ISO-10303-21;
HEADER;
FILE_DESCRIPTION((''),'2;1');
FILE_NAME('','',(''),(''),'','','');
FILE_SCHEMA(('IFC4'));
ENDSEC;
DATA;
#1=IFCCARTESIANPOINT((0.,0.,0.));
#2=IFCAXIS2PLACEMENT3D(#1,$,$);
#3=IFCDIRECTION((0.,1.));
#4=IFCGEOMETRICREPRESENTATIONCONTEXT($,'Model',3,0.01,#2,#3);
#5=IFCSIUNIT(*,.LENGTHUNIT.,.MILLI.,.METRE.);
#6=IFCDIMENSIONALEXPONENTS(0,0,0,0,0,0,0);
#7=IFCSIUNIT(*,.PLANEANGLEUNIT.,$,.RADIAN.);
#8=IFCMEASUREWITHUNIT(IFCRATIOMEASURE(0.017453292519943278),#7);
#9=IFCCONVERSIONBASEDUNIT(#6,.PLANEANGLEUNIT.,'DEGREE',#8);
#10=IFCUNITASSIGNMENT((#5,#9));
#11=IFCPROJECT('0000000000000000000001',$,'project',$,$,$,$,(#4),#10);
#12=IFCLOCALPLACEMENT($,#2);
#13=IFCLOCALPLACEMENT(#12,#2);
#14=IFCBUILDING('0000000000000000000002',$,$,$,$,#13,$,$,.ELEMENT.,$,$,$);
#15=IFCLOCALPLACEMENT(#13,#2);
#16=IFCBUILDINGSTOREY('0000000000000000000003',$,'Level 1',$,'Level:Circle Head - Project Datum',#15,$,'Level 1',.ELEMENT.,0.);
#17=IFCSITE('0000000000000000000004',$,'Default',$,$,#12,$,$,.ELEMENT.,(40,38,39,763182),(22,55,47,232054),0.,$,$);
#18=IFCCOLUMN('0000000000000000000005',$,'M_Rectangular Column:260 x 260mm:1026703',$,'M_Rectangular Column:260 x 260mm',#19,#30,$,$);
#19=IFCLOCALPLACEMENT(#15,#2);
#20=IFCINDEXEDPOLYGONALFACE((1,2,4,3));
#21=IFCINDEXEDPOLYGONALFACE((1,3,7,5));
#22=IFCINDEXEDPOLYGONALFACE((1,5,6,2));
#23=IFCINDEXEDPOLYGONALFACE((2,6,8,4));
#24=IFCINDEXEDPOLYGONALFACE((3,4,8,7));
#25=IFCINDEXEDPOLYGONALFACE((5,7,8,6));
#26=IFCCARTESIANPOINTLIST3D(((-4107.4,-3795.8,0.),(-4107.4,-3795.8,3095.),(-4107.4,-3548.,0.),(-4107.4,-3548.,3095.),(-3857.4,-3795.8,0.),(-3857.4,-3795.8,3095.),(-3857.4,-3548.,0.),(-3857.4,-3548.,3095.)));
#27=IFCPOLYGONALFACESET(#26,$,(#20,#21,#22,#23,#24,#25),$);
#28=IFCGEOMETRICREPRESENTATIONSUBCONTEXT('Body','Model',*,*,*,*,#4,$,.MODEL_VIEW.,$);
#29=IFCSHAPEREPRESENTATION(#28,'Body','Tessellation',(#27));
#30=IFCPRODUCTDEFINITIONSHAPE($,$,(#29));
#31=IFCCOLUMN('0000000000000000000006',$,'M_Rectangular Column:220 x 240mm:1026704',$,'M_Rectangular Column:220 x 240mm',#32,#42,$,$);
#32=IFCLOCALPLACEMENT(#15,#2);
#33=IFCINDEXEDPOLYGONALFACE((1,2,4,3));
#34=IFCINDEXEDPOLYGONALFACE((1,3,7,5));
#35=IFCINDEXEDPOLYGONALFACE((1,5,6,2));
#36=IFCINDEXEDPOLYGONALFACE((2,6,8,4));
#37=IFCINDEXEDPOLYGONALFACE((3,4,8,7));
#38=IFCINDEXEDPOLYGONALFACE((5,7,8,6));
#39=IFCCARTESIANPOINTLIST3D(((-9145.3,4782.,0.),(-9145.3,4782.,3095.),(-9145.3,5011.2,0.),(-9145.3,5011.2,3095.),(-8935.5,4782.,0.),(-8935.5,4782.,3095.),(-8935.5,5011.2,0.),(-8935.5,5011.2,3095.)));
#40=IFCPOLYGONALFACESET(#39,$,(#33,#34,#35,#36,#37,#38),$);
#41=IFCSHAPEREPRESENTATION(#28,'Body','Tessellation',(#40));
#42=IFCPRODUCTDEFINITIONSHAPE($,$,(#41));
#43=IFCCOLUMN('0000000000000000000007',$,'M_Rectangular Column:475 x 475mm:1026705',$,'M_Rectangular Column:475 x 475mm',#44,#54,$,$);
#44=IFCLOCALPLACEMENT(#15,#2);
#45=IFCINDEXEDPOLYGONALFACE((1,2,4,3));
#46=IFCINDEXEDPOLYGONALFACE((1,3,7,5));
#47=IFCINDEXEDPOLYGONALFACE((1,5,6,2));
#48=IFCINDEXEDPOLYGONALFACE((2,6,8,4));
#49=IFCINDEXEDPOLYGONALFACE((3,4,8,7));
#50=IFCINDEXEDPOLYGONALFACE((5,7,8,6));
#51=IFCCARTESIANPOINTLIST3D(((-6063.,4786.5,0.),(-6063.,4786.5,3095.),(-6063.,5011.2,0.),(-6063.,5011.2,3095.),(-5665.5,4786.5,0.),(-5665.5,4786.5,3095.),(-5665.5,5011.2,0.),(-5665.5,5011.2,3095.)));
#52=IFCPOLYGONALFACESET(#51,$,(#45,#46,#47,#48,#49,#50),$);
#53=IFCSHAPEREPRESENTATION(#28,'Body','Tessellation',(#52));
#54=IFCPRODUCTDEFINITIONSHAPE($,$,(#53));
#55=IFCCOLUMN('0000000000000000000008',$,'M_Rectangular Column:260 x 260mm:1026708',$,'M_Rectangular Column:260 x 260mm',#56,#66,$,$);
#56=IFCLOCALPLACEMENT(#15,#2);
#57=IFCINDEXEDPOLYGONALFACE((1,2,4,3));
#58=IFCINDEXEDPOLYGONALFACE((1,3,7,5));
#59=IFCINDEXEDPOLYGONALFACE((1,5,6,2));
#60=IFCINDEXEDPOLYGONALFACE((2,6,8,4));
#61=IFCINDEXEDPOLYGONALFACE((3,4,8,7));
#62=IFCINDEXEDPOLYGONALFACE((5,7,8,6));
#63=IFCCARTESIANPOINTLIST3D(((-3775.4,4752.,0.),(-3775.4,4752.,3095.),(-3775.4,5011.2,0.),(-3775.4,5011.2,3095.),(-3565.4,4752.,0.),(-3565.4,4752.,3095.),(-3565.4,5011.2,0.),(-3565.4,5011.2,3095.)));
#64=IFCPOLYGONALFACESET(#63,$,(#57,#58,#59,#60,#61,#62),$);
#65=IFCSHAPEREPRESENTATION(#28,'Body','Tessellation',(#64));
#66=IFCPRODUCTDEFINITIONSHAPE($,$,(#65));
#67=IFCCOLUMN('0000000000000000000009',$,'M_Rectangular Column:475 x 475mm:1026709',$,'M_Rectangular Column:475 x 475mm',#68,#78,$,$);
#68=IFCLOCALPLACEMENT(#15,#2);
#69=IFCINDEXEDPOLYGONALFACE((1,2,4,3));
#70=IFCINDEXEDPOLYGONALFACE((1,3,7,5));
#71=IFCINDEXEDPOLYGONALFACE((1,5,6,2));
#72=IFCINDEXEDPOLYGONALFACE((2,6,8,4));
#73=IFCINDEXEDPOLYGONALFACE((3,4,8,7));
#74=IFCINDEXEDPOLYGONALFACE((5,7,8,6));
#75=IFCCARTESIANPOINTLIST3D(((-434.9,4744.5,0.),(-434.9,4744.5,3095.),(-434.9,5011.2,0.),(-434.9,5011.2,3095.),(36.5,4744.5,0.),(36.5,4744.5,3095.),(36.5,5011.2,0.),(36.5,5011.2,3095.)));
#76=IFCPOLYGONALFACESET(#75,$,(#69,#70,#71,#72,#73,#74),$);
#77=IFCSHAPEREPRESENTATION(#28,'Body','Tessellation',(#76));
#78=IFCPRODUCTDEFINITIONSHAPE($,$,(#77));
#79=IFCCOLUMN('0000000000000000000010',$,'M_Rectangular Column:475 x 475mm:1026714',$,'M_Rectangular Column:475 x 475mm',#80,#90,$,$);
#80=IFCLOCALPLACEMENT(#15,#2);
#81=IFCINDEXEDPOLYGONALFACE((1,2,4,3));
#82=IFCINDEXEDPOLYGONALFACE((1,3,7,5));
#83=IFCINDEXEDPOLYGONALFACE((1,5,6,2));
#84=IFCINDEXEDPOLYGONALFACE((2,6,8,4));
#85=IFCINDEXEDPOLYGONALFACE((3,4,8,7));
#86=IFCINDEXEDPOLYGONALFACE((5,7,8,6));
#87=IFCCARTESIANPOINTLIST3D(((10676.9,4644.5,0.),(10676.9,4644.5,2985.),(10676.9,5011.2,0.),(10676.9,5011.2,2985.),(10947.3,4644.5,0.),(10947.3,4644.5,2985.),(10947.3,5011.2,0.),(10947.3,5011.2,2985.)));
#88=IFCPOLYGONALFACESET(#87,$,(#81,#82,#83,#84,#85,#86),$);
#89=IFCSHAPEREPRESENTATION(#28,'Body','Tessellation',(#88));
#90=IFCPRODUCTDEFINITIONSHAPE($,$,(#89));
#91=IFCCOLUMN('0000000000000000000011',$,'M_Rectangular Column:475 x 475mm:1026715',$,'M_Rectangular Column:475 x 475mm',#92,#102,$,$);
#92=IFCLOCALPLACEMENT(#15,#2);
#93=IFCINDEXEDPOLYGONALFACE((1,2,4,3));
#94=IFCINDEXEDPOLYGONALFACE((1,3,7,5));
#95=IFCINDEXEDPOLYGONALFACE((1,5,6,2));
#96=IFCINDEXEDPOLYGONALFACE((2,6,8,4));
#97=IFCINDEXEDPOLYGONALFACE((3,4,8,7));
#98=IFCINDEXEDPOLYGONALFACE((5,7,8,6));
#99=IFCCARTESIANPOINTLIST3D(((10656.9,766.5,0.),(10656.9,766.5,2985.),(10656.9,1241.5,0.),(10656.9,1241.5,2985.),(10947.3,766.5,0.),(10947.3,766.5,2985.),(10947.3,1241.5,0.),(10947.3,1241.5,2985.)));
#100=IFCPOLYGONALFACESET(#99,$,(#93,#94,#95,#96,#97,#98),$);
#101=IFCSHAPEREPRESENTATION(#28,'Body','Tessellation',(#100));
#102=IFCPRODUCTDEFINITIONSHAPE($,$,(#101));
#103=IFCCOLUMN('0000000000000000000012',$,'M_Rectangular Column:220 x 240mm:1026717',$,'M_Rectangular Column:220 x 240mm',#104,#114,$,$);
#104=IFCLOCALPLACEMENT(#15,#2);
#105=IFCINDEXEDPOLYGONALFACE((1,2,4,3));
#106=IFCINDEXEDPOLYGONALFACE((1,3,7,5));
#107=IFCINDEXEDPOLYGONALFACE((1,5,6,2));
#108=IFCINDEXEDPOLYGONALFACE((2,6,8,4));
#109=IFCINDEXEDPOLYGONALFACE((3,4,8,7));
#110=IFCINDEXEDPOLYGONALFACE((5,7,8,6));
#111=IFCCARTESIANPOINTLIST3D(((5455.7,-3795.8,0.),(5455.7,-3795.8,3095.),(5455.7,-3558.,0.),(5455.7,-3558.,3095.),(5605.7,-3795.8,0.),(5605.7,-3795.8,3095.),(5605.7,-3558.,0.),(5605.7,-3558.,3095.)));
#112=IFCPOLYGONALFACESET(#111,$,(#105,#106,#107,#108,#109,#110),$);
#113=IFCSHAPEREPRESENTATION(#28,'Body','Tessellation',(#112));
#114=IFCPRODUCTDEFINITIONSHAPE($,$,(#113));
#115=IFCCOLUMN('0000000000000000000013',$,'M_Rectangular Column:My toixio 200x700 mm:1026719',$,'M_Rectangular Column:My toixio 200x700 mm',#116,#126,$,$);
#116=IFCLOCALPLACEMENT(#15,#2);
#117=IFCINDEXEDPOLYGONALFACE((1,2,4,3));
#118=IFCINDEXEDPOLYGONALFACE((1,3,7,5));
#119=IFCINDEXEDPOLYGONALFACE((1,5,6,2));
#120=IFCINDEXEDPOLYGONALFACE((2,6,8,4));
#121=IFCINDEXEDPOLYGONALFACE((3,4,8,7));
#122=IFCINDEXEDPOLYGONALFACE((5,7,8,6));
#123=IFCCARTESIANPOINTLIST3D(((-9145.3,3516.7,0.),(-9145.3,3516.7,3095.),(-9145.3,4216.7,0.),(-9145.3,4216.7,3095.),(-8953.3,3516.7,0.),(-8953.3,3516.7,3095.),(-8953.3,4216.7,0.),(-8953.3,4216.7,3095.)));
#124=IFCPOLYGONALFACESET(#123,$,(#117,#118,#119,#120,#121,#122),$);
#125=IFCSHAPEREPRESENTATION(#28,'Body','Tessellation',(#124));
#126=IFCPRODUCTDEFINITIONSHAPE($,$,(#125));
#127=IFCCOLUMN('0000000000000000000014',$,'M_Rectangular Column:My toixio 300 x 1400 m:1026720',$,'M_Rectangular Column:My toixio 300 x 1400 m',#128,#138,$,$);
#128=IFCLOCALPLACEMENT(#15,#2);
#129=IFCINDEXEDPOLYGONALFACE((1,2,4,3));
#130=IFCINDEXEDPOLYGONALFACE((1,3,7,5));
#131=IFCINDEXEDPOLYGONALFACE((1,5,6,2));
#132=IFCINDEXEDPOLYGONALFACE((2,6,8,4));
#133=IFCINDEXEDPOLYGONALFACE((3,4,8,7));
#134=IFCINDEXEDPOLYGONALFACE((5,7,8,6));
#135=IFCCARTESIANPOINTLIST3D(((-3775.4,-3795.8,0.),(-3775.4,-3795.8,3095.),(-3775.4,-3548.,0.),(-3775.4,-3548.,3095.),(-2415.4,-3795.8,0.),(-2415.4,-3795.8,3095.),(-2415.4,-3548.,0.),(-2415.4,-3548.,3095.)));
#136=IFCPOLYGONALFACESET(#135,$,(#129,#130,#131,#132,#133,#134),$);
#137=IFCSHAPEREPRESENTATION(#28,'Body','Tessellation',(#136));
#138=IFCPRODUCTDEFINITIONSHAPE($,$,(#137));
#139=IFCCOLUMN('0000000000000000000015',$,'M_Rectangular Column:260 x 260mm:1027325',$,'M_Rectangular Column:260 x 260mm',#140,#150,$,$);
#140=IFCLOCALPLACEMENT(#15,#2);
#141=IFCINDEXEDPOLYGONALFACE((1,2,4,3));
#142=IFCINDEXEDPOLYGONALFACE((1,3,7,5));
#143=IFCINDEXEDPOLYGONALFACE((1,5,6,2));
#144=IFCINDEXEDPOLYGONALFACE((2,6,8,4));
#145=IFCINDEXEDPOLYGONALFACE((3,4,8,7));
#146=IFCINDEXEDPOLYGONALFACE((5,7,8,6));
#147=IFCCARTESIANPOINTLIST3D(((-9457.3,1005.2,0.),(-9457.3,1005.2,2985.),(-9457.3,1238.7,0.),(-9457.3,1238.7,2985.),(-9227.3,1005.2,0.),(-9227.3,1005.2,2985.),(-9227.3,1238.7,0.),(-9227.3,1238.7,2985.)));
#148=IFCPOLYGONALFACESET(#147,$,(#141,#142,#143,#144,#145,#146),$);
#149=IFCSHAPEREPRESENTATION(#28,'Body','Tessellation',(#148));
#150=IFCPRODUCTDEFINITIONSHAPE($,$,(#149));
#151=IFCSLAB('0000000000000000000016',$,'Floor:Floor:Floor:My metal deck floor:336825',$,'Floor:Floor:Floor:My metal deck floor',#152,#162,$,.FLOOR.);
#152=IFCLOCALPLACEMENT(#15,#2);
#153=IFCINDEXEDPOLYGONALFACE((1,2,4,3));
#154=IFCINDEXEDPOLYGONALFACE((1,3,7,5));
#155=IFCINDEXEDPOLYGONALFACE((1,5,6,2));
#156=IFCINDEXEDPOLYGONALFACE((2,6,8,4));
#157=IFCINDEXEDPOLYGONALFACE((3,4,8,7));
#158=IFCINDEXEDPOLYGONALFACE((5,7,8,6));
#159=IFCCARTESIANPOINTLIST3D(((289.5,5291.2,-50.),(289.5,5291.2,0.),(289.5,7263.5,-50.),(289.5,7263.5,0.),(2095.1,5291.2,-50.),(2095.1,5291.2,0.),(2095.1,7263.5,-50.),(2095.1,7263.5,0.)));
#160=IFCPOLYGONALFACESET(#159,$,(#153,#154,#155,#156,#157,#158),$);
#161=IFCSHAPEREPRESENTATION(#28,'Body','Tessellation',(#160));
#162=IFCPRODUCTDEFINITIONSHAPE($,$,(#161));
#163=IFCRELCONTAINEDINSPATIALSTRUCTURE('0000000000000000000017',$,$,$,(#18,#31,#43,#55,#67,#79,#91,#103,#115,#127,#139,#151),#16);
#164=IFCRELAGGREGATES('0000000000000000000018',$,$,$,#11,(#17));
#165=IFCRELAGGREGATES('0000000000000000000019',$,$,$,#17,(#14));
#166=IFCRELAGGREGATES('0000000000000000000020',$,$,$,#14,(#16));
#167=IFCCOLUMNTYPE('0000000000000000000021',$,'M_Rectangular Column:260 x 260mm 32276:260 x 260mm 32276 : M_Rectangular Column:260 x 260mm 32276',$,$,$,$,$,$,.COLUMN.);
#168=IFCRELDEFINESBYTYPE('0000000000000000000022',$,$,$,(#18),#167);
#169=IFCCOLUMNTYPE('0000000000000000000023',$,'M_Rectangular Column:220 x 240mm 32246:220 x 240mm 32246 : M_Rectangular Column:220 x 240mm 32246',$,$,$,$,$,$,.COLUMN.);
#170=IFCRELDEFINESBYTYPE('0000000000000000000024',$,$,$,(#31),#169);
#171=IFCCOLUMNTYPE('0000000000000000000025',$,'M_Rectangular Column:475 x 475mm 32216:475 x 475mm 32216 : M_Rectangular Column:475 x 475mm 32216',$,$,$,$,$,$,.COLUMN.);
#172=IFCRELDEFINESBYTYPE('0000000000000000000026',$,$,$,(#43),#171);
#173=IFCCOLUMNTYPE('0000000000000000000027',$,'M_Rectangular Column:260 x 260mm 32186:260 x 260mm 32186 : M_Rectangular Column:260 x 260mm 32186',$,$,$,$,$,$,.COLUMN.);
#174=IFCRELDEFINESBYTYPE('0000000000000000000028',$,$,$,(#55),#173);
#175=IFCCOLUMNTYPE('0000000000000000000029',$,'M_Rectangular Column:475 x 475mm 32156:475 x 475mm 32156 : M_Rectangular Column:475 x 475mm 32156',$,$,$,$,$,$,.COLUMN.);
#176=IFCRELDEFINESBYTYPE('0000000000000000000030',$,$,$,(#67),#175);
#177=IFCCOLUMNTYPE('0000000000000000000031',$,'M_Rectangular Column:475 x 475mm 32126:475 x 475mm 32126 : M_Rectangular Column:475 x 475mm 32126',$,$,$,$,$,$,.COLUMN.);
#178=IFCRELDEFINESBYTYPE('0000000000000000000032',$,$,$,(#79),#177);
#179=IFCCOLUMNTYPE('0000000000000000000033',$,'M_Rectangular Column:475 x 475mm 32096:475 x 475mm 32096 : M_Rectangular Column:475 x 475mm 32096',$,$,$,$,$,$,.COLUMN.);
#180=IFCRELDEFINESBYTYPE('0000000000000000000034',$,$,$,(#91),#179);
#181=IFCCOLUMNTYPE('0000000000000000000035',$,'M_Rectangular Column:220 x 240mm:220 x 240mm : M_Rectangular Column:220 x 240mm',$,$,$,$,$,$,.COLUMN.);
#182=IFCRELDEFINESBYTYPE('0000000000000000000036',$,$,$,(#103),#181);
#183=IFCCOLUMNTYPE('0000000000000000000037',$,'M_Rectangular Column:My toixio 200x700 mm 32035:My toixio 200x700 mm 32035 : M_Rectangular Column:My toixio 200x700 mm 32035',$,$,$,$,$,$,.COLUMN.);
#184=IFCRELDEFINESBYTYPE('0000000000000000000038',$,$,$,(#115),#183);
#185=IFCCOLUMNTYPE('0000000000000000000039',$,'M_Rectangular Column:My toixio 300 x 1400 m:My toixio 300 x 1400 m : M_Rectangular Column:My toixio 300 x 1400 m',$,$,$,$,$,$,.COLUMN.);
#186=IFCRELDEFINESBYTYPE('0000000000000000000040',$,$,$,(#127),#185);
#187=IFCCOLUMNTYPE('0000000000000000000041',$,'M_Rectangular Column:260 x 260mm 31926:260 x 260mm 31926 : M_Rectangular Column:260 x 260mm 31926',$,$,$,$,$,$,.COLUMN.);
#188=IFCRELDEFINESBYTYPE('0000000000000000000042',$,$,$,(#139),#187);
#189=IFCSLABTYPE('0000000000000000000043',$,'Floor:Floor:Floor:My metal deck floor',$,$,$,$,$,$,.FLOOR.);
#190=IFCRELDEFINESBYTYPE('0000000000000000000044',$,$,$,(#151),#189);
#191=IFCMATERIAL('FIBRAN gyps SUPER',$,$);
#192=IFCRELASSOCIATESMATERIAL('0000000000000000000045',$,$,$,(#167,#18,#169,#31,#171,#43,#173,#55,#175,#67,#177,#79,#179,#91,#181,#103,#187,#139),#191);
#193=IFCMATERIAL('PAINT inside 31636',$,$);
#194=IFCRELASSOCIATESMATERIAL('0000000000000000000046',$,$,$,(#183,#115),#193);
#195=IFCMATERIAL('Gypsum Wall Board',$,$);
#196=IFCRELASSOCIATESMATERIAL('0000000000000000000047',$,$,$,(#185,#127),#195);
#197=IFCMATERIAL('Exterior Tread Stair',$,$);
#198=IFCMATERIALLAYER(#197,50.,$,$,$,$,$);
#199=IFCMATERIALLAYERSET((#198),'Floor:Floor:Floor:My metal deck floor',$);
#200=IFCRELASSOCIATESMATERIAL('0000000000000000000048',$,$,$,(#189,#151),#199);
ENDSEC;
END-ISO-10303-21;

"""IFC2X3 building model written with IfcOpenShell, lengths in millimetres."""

from ifc_helpers import new_model, entity, si_unit, converted_unit, direction, frame, frame_2d, origin, origin_2d_with_axis, place, context, subcontext, project, spatial, rectangle, extrude, source, transform, mapped, material, layer, layer_set, layer_usage, type_object, type_shapes, element, save


model = new_model("IFC2X3")

# Units and contexts
model_context = context("Model", 3, precision=0.01, world=origin(), true_north=direction((0.0, 1.0)))
body_context = subcontext(model_context, "Body", "Model", "MODEL_VIEW")
ifc_project = project(units=[si_unit("LENGTHUNIT", "METRE", prefix="MILLI"), converted_unit("PLANEANGLEUNIT", "DEGREE", entity("IfcRatioMeasure", 0.017453292519943278), si_unit("PLANEANGLEUNIT", "RADIAN"), dimensions=[0, 0, 0, 0, 0, 0, 0])], contexts=[model_context])

# Site, building, storey
site_placement = place(None, origin())
site = spatial("IfcSite", under=ifc_project, at=site_placement, Name="Default", CompositionType="ELEMENT", RefLatitude=(40, 38, 39, 763182), RefLongitude=(22, 55, 47, 232054), RefElevation=0.0)
building_placement = place(site_placement, origin())
building = spatial("IfcBuilding", under=site, at=building_placement, CompositionType="ELEMENT")
storey_placement = place(building_placement, origin())
storey = spatial("IfcBuildingStorey", under=building, at=storey_placement, Name="Level 1", ObjectType="Level:Circle Head - Project Datum", LongName="Level 1", CompositionType="ELEMENT", Elevation=0.0)

# Columns
ifc_material_1 = material(Name="FIBRAN gyps SUPER")
column_type_1 = type_object("IfcColumnType", Name="M_Rectangular Column:260 x 260mm 32276:260 x 260mm 32276 : M_Rectangular Column:260 x 260mm 32276", PredefinedType="COLUMN", material=ifc_material_1)
shared_shape_1 = source(origin(), body_context, "Body", "SweptSolid", [
    extrude(rectangle(XDim=247.9, YDim=250.0, at=frame_2d((0.0, 0.0), x_axis=(1.0, 0.0))), frame((-3982.4, -3671.9, 0.0), z_axis=(0.0, 0.0, 1.0), x_axis=(0.0, -1.0, 0.0)), (0.0, 0.0, 1.0), 3095.0),
])
type_shapes(column_type_1, [shared_shape_1])
column_1_placement = place(storey_placement, origin())
element("IfcColumn", 1, at=column_1_placement, inside=storey, type_object=column_type_1, material=ifc_material_1, Name="M_Rectangular Column:260 x 260mm:1026703", ObjectType="M_Rectangular Column:260 x 260mm", context=body_context, shape_type="MappedRepresentation", body=[
    mapped(shared_shape_1, transform((0.0, 0.0, 0.0), scale=1.0)),
])
column_type_2 = type_object("IfcColumnType", Name="M_Rectangular Column:220 x 240mm 32246:220 x 240mm 32246 : M_Rectangular Column:220 x 240mm 32246", PredefinedType="COLUMN", material=ifc_material_1)
shared_shape_2 = source(origin(), body_context, "Body", "SweptSolid", [
    extrude(rectangle(XDim=229.1, YDim=209.9, at=frame_2d((0.0, 0.0), x_axis=(1.0, 0.0))), frame((-9040.4, 4896.6, 0.0), z_axis=(0.0, 0.0, 1.0), x_axis=(0.0, -1.0, 0.0)), (0.0, 0.0, 1.0), 3095.0),
])
type_shapes(column_type_2, [shared_shape_2])
column_2_placement = place(storey_placement, origin())
element("IfcColumn", 2, at=column_2_placement, inside=storey, type_object=column_type_2, material=ifc_material_1, Name="M_Rectangular Column:220 x 240mm:1026704", ObjectType="M_Rectangular Column:220 x 240mm", context=body_context, shape_type="MappedRepresentation", body=[
    mapped(shared_shape_2, transform((0.0, 0.0, 0.0), scale=1.0)),
])
column_type_3 = type_object("IfcColumnType", Name="M_Rectangular Column:475 x 475mm 32216:475 x 475mm 32216 : M_Rectangular Column:475 x 475mm 32216", PredefinedType="COLUMN", material=ifc_material_1)
shared_shape_3 = source(origin(), body_context, "Body", "SweptSolid", [
    extrude(rectangle(XDim=224.6, YDim=397.5, at=frame_2d((0.0, 0.0), x_axis=(1.0, 0.0))), frame((-5864.2, 4898.8, 0.0), z_axis=(0.0, 0.0, 1.0), x_axis=(0.0, -1.0, 0.0)), (0.0, 0.0, 1.0), 3095.0),
])
type_shapes(column_type_3, [shared_shape_3])
column_3_placement = place(storey_placement, origin())
element("IfcColumn", 3, at=column_3_placement, inside=storey, type_object=column_type_3, material=ifc_material_1, Name="M_Rectangular Column:475 x 475mm:1026705", ObjectType="M_Rectangular Column:475 x 475mm", context=body_context, shape_type="MappedRepresentation", body=[
    mapped(shared_shape_3, transform((0.0, 0.0, 0.0), scale=1.0)),
])
column_type_4 = type_object("IfcColumnType", Name="M_Rectangular Column:260 x 260mm 32186:260 x 260mm 32186 : M_Rectangular Column:260 x 260mm 32186", PredefinedType="COLUMN", material=ifc_material_1)
shared_shape_4 = source(origin(), body_context, "Body", "SweptSolid", [
    extrude(rectangle(XDim=259.1, YDim=210.0, at=origin_2d_with_axis()), frame((-3670.4, 4881.6, 0.0), z_axis=(0.0, 0.0, 1.0), x_axis=(0.0, -1.0, 0.0)), (0.0, 0.0, 1.0), 3095.0),
])
type_shapes(column_type_4, [shared_shape_4])
column_4_placement = place(storey_placement, origin())
element("IfcColumn", 4, at=column_4_placement, inside=storey, type_object=column_type_4, material=ifc_material_1, Name="M_Rectangular Column:260 x 260mm:1026708", ObjectType="M_Rectangular Column:260 x 260mm", context=body_context, shape_type="MappedRepresentation", body=[
    mapped(shared_shape_4, transform((0.0, 0.0, 0.0), scale=1.0)),
])
column_type_5 = type_object("IfcColumnType", Name="M_Rectangular Column:475 x 475mm 32156:475 x 475mm 32156 : M_Rectangular Column:475 x 475mm 32156", PredefinedType="COLUMN", material=ifc_material_1)
shared_shape_5 = source(origin(), body_context, "Body", "SweptSolid", [
    extrude(rectangle(XDim=266.6, YDim=471.4, at=frame_2d((0.0, 0.0), x_axis=(1.0, 0.0))), frame((-199.2, 4877.8, 0.0), z_axis=(0.0, 0.0, 1.0), x_axis=(0.0, -1.0, 0.0)), (0.0, 0.0, 1.0), 3095.0),
])
type_shapes(column_type_5, [shared_shape_5])
column_5_placement = place(storey_placement, origin())
element("IfcColumn", 5, at=column_5_placement, inside=storey, type_object=column_type_5, material=ifc_material_1, Name="M_Rectangular Column:475 x 475mm:1026709", ObjectType="M_Rectangular Column:475 x 475mm", context=body_context, shape_type="MappedRepresentation", body=[
    mapped(shared_shape_5, transform((0.0, 0.0, 0.0), scale=1.0)),
])
column_type_6 = type_object("IfcColumnType", Name="M_Rectangular Column:475 x 475mm 32126:475 x 475mm 32126 : M_Rectangular Column:475 x 475mm 32126", PredefinedType="COLUMN", material=ifc_material_1)
shared_shape_6 = source(origin(), body_context, "Body", "SweptSolid", [
    extrude(rectangle(XDim=366.6, YDim=270.4, at=frame_2d((0.0, 0.0), x_axis=(1.0, 0.0))), frame((10812.1, 4827.8, 0.0), z_axis=(0.0, 0.0, 1.0), x_axis=(0.0, -1.0, 0.0)), (0.0, 0.0, 1.0), 2985.0),
])
type_shapes(column_type_6, [shared_shape_6])
column_6_placement = place(storey_placement, origin())
element("IfcColumn", 6, at=column_6_placement, inside=storey, type_object=column_type_6, material=ifc_material_1, Name="M_Rectangular Column:475 x 475mm:1026714", ObjectType="M_Rectangular Column:475 x 475mm", context=body_context, shape_type="MappedRepresentation", body=[
    mapped(shared_shape_6, transform((0.0, 0.0, 0.0), scale=1.0)),
])
column_type_7 = type_object("IfcColumnType", Name="M_Rectangular Column:475 x 475mm 32096:475 x 475mm 32096 : M_Rectangular Column:475 x 475mm 32096", PredefinedType="COLUMN", material=ifc_material_1)
shared_shape_7 = source(origin(), body_context, "Body", "SweptSolid", [
    extrude(rectangle(XDim=475.0, YDim=290.4, at=origin_2d_with_axis()), frame((10802.1, 1004.0, 0.0), z_axis=(0.0, 0.0, 1.0), x_axis=(0.0, -1.0, 0.0)), (0.0, 0.0, 1.0), 2985.0),
])
type_shapes(column_type_7, [shared_shape_7])
column_7_placement = place(storey_placement, origin())
element("IfcColumn", 7, at=column_7_placement, inside=storey, type_object=column_type_7, material=ifc_material_1, Name="M_Rectangular Column:475 x 475mm:1026715", ObjectType="M_Rectangular Column:475 x 475mm", context=body_context, shape_type="MappedRepresentation", body=[
    mapped(shared_shape_7, transform((0.0, 0.0, 0.0), scale=1.0)),
])
column_type_8 = type_object("IfcColumnType", Name="M_Rectangular Column:220 x 240mm:220 x 240mm : M_Rectangular Column:220 x 240mm", PredefinedType="COLUMN", material=ifc_material_1)
shared_shape_8 = source(origin(), body_context, "Body", "SweptSolid", [
    extrude(rectangle(XDim=237.9, YDim=150.0, at=frame_2d((0.0, 0.0), x_axis=(1.0, 0.0))), frame((5530.7, -3676.9, 0.0), z_axis=(0.0, 0.0, 1.0), x_axis=(0.0, -1.0, 0.0)), (0.0, 0.0, 1.0), 3095.0),
])
type_shapes(column_type_8, [shared_shape_8])
column_8_placement = place(storey_placement, origin())
element("IfcColumn", 8, at=column_8_placement, inside=storey, type_object=column_type_8, material=ifc_material_1, Name="M_Rectangular Column:220 x 240mm:1026717", ObjectType="M_Rectangular Column:220 x 240mm", context=body_context, shape_type="MappedRepresentation", body=[
    mapped(shared_shape_8, transform((0.0, 0.0, 0.0), scale=1.0)),
])
ifc_material_2 = material(Name="PAINT inside 31636")
column_type_9 = type_object("IfcColumnType", Name="M_Rectangular Column:My toixio 200x700 mm 32035:My toixio 200x700 mm 32035 : M_Rectangular Column:My toixio 200x700 mm 32035", PredefinedType="COLUMN", material=ifc_material_2)
shared_shape_9 = source(origin(), body_context, "Body", "SweptSolid", [
    extrude(rectangle(XDim=700.0, YDim=192.0, at=frame_2d((0.0, 0.0), x_axis=(1.0, 0.0))), frame((-9049.3, 3866.7, 0.0), z_axis=(0.0, 0.0, 1.0), x_axis=(0.0, -1.0, 0.0)), (0.0, 0.0, 1.0), 3095.0),
])
type_shapes(column_type_9, [shared_shape_9])
column_9_placement = place(storey_placement, origin())
element("IfcColumn", 9, at=column_9_placement, inside=storey, type_object=column_type_9, material=ifc_material_2, Name="M_Rectangular Column:My toixio 200x700 mm:1026719", ObjectType="M_Rectangular Column:My toixio 200x700 mm", context=body_context, shape_type="MappedRepresentation", body=[
    mapped(shared_shape_9, transform((0.0, 0.0, 0.0), scale=1.0)),
])
ifc_material_3 = material(Name="Gypsum Wall Board")
column_type_10 = type_object("IfcColumnType", Name="M_Rectangular Column:My toixio 300 x 1400 m:My toixio 300 x 1400 m : M_Rectangular Column:My toixio 300 x 1400 m", PredefinedType="COLUMN", material=ifc_material_3)
shared_shape_10 = source(origin(), body_context, "Body", "SweptSolid", [
    extrude(rectangle(XDim=247.9, YDim=1360.0, at=frame_2d((0.0, 0.0), x_axis=(1.0, 0.0))), frame((-3095.4, -3671.9, 0.0), z_axis=(0.0, 0.0, 1.0), x_axis=(0.0, -1.0, 0.0)), (0.0, 0.0, 1.0), 3095.0),
])
type_shapes(column_type_10, [shared_shape_10])
column_10_placement = place(storey_placement, origin())
element("IfcColumn", 10, at=column_10_placement, inside=storey, type_object=column_type_10, material=ifc_material_3, Name="M_Rectangular Column:My toixio 300 x 1400 m:1026720", ObjectType="M_Rectangular Column:My toixio 300 x 1400 m", context=body_context, shape_type="MappedRepresentation", body=[
    mapped(shared_shape_10, transform((0.0, 0.0, 0.0), scale=1.0)),
])
column_type_11 = type_object("IfcColumnType", Name="M_Rectangular Column:260 x 260mm 31926:260 x 260mm 31926 : M_Rectangular Column:260 x 260mm 31926", PredefinedType="COLUMN", material=ifc_material_1)
shared_shape_11 = source(origin(), body_context, "Body", "SweptSolid", [
    extrude(rectangle(XDim=233.5, YDim=230.0, at=origin_2d_with_axis()), frame((-9342.3, 1121.9, 0.0), z_axis=(0.0, 0.0, 1.0), x_axis=(0.0, -1.0, 0.0)), (0.0, 0.0, 1.0), 2985.0),
])
type_shapes(column_type_11, [shared_shape_11])
column_11_placement = place(storey_placement, origin())
element("IfcColumn", 11, at=column_11_placement, inside=storey, type_object=column_type_11, material=ifc_material_1, Name="M_Rectangular Column:260 x 260mm:1027325", ObjectType="M_Rectangular Column:260 x 260mm", context=body_context, shape_type="MappedRepresentation", body=[
    mapped(shared_shape_11, transform((0.0, 0.0, 0.0), scale=1.0)),
])

# Slab
ifc_material_4 = material(Name="Exterior Tread Stair")
ifc_layer_1 = layer(ifc_material_4, 50.0)
ifc_layer_set_1 = layer_set([ifc_layer_1], Name="Floor:Floor:Floor:My metal deck floor")
ifc_layer_usage_1 = layer_usage(ifc_layer_set_1, "AXIS3", "POSITIVE", 0.0)
slab_type_1 = type_object("IfcSlabType", Name="Floor:Floor:Floor:My metal deck floor", PredefinedType="FLOOR", material=ifc_layer_set_1)
slab_1_placement = place(storey_placement, origin())
element("IfcSlab", 12, at=slab_1_placement, inside=storey, type_object=slab_type_1, material=ifc_layer_usage_1, Name="Floor:Floor:Floor:My metal deck floor:336825", ObjectType="Floor:Floor:Floor:My metal deck floor", PredefinedType="FLOOR", context=body_context, shape_type="SweptSolid", body=[
    extrude(rectangle(XDim=1972.4, YDim=1805.6, at=frame_2d((0.0, 0.0), x_axis=(1.0, 0.0))), frame((1192.3, 6277.4, 0.0), z_axis=(0.0, 0.0, -1.0), x_axis=(0.0, 1.0, 0.0)), (0.0, 0.0, 1.0), 50.0),
])

save(model, "model.ifc")
